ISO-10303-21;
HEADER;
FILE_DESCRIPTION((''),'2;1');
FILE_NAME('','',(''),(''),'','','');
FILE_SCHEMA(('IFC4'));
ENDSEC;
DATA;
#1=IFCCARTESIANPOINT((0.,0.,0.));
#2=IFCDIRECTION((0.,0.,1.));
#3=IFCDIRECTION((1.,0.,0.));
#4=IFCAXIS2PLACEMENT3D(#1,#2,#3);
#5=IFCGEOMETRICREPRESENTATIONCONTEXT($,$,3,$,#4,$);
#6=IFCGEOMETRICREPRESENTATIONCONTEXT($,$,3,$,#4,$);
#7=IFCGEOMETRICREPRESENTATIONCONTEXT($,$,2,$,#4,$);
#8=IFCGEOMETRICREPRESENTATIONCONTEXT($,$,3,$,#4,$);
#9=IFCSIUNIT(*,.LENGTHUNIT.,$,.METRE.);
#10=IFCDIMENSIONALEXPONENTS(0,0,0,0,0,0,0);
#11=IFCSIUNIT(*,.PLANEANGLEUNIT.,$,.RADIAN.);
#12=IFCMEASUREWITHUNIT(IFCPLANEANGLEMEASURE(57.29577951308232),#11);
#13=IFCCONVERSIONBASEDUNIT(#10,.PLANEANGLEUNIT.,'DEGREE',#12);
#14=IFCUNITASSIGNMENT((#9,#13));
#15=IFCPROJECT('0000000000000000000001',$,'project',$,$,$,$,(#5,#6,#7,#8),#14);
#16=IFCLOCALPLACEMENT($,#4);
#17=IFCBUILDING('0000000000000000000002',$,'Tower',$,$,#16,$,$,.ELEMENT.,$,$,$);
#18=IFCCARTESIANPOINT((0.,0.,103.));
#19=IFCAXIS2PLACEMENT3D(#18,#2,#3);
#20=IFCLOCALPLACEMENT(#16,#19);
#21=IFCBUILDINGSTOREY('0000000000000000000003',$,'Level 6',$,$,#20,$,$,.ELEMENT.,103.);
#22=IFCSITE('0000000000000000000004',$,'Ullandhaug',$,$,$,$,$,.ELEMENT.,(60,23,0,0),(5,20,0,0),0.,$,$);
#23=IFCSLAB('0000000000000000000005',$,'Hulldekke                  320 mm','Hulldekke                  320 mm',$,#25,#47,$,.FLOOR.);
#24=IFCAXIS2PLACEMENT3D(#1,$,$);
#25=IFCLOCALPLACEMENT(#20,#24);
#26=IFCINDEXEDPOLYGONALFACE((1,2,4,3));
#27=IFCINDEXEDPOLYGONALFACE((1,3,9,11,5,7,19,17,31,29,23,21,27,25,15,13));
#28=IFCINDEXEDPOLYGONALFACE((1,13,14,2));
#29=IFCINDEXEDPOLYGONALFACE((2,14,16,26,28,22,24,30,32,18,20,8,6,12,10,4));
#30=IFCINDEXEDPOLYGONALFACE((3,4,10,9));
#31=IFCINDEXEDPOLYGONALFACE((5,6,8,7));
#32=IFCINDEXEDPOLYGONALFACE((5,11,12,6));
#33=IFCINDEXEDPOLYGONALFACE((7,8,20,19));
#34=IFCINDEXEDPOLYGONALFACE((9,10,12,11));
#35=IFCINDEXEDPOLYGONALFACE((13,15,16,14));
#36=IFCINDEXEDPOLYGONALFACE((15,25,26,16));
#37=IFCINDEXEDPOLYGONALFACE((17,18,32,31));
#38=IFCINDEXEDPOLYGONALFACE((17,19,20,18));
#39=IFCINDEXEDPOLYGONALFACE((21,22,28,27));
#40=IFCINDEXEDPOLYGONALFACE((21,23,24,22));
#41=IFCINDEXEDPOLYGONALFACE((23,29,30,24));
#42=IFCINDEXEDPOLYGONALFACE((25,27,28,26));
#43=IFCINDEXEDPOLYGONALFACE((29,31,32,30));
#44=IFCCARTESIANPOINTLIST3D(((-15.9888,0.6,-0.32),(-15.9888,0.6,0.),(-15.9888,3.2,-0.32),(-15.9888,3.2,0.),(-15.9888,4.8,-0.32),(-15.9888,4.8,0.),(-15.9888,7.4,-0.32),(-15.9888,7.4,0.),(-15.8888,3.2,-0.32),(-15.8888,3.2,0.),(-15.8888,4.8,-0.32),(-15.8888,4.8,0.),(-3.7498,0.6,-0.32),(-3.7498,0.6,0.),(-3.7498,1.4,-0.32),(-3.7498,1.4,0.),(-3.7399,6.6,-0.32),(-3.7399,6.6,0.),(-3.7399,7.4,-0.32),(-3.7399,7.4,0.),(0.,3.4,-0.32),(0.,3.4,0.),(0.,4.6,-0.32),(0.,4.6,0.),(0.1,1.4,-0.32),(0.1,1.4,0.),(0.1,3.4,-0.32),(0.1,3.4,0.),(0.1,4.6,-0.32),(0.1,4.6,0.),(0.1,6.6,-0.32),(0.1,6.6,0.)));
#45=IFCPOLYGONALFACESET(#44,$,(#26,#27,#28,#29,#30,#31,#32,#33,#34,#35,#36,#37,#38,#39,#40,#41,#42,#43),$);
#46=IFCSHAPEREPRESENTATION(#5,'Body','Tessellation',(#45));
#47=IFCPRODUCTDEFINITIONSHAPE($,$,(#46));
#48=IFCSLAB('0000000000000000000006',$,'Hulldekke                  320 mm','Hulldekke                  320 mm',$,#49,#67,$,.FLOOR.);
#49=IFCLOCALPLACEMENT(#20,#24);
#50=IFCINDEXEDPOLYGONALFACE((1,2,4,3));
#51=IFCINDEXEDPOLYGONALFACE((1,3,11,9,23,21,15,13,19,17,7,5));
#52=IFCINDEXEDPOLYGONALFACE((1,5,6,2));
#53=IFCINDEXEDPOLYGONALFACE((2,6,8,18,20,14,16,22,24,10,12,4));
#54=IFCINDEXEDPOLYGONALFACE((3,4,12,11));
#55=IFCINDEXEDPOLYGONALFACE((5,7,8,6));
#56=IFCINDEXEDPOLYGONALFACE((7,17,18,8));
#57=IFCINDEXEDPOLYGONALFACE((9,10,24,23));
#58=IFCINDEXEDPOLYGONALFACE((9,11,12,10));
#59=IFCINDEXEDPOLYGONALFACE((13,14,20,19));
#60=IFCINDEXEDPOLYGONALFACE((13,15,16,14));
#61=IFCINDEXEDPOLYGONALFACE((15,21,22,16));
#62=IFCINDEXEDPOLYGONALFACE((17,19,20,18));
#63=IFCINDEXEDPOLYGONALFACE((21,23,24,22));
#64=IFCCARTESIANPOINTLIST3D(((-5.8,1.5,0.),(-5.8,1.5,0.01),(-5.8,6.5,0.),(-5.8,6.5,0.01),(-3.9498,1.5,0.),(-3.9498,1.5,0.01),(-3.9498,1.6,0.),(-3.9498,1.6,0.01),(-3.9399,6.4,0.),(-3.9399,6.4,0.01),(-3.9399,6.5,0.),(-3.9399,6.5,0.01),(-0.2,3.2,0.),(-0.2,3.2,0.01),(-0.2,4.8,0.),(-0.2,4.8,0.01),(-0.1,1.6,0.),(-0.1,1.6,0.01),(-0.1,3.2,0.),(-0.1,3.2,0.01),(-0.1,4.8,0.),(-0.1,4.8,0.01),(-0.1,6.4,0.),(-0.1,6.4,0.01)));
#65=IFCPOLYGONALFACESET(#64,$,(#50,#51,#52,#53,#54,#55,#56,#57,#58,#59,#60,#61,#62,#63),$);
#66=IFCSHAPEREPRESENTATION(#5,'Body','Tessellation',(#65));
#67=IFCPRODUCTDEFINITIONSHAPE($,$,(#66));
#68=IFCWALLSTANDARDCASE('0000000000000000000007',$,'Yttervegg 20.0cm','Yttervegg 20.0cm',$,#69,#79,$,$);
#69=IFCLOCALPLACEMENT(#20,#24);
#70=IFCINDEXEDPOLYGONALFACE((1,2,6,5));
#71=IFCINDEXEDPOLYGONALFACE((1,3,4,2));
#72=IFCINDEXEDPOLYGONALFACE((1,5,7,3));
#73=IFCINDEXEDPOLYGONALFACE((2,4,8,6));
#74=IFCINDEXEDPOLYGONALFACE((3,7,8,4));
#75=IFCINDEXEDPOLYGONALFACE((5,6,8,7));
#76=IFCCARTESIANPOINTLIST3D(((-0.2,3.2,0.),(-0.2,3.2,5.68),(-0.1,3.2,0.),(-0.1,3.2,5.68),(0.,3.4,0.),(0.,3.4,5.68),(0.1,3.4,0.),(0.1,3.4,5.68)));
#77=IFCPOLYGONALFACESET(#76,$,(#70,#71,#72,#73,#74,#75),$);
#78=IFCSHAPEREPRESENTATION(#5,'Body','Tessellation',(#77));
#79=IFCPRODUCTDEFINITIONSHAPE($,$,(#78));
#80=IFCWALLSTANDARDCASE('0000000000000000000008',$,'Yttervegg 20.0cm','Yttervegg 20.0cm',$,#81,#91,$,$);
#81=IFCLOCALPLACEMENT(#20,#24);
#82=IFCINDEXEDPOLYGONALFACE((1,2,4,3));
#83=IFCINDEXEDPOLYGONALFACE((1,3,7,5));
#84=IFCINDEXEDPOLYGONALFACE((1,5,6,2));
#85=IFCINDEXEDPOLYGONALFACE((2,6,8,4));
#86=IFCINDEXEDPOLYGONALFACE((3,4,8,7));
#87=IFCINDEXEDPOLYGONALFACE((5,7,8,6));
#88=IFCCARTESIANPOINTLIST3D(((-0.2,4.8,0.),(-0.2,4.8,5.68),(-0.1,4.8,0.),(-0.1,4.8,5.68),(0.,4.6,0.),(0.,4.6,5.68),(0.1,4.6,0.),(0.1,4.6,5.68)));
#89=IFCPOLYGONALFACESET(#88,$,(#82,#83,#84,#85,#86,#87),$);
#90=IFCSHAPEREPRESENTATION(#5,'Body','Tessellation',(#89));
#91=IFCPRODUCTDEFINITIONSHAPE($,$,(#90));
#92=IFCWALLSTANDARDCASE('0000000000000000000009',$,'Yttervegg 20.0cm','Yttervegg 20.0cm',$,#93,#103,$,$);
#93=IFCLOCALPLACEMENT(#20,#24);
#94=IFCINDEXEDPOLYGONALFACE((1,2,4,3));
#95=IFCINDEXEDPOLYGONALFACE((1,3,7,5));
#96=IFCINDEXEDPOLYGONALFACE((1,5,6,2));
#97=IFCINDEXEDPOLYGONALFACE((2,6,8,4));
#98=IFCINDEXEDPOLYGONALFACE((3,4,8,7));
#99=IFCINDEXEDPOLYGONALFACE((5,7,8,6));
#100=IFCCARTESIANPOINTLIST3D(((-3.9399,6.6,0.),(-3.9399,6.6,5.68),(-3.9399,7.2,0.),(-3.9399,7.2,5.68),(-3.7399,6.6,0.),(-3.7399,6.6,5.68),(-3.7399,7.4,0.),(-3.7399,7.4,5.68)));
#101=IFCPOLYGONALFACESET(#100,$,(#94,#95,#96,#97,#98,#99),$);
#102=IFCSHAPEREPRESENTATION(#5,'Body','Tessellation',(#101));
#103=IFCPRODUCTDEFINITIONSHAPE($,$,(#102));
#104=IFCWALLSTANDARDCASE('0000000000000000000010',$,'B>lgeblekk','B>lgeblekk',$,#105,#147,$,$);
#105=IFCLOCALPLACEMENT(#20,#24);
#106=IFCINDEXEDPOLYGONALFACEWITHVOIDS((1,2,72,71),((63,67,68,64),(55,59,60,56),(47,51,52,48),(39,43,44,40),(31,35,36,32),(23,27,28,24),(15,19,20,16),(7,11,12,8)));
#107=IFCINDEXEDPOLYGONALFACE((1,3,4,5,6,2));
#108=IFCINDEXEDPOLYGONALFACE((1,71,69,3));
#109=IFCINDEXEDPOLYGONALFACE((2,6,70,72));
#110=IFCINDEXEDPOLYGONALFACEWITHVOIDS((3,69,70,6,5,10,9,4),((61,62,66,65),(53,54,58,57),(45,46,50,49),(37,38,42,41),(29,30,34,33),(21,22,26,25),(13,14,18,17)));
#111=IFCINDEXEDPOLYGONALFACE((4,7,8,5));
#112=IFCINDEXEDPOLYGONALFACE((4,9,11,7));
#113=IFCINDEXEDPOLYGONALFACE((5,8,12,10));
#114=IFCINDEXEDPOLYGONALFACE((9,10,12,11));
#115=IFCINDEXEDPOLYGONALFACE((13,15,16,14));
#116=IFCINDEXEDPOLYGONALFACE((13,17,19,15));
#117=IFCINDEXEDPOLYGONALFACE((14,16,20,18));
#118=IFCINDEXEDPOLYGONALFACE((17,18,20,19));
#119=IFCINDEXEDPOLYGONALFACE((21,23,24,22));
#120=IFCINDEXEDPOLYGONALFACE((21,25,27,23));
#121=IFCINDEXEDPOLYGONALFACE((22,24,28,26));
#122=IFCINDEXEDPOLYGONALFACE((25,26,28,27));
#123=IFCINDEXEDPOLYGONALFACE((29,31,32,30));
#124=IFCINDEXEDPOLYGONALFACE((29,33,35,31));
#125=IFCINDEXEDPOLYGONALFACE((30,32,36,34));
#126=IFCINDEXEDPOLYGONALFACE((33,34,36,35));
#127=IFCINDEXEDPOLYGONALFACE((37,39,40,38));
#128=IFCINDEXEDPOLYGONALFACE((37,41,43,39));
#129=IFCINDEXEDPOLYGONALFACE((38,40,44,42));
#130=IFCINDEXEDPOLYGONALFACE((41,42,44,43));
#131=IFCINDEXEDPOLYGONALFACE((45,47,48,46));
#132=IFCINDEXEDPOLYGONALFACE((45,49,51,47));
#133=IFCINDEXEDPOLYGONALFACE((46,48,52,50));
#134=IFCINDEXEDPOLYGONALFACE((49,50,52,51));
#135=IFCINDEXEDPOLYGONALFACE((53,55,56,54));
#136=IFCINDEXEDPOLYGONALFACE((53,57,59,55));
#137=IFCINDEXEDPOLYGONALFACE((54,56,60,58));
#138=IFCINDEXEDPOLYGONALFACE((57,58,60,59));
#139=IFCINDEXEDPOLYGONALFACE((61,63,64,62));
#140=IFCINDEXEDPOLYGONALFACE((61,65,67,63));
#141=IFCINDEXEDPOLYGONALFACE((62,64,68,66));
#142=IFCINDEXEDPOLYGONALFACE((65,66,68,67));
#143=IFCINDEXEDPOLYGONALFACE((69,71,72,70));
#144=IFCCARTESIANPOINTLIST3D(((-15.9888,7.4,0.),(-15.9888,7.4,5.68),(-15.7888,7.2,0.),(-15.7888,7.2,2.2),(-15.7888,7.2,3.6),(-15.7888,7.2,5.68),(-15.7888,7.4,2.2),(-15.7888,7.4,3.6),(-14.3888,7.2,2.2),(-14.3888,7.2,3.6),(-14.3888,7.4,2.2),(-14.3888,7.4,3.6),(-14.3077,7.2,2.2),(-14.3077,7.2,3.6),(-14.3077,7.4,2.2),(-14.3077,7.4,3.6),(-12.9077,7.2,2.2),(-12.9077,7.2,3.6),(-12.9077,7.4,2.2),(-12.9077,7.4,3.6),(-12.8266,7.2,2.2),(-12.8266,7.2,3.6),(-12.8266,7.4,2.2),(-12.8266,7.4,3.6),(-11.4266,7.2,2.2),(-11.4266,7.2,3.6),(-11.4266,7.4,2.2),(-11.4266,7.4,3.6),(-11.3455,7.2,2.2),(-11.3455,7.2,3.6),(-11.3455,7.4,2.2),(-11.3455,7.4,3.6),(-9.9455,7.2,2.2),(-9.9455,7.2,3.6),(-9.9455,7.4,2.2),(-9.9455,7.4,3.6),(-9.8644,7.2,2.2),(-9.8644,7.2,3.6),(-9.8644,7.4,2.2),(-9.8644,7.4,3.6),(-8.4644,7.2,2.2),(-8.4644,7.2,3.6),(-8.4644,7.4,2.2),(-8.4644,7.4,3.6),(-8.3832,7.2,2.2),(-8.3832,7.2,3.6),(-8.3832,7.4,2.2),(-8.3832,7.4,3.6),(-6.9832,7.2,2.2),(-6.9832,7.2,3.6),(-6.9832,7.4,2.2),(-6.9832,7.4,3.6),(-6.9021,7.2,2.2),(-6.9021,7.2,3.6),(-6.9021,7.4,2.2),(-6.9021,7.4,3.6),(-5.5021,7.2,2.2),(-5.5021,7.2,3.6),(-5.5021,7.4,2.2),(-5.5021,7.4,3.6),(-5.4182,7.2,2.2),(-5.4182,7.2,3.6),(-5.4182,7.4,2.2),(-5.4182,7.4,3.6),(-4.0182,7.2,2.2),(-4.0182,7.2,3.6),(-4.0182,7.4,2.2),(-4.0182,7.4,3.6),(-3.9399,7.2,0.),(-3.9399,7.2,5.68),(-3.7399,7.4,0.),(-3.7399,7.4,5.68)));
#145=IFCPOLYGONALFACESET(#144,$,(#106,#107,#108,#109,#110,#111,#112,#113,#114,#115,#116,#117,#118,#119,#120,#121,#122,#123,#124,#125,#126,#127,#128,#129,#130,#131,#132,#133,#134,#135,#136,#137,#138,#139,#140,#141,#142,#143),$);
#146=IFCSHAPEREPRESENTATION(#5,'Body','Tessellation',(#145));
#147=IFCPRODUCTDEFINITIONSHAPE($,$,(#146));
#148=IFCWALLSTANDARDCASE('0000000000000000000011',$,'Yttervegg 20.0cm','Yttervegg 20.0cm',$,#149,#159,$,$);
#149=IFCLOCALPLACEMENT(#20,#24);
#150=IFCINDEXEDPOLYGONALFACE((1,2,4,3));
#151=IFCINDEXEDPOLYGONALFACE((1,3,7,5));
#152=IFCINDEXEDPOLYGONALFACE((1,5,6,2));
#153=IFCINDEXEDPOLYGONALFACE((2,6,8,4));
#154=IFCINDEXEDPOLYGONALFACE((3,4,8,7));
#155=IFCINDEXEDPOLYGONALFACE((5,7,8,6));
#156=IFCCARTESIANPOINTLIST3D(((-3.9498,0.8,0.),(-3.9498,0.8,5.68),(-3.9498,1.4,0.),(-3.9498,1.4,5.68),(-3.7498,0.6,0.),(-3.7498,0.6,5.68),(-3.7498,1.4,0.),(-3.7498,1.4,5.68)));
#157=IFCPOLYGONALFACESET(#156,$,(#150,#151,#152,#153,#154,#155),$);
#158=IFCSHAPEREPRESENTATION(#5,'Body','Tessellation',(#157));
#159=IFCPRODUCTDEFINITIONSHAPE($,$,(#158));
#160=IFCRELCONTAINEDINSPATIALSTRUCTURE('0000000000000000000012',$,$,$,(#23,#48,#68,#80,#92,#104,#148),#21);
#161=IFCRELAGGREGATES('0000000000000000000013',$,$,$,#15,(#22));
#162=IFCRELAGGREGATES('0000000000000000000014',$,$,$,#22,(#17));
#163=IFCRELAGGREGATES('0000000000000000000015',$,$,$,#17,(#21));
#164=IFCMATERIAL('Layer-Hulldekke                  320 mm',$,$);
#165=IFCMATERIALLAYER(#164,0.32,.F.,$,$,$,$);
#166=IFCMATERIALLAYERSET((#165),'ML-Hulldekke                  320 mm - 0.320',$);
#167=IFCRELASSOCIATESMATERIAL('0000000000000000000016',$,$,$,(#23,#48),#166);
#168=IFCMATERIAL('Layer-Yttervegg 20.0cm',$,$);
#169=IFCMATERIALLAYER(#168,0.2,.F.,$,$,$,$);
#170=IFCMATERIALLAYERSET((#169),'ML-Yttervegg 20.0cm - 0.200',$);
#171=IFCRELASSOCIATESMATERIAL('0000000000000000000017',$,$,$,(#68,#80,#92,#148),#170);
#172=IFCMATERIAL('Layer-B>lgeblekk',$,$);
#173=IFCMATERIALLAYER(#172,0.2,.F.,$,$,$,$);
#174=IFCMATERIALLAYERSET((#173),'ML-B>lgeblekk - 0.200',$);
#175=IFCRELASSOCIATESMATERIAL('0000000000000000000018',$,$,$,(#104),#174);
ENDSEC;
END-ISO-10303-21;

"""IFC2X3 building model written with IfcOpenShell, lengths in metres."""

from ifc_helpers import new_model, entity, si_unit, converted_unit, frame, origin_with_axes, place, context, project, spatial, polyline, outline, extrude, material, layer, layer_set, layer_usage, element, save


model = new_model("IFC2X3")

# Units and contexts
context_of_model_1 = context(None, 3, world=origin_with_axes())
context_of_model_2 = context(None, 3, world=origin_with_axes())
context_of_model_3 = context(None, 2, world=origin_with_axes())
context_of_model_4 = context(None, 3, world=origin_with_axes())
ifc_project = project(units=[si_unit("LENGTHUNIT", "METRE"), converted_unit("PLANEANGLEUNIT", "DEGREE", entity("IfcPlaneAngleMeasure", 57.29577951308232), si_unit("PLANEANGLEUNIT", "RADIAN"), dimensions=[0, 0, 0, 0, 0, 0, 0])], contexts=[context_of_model_1, context_of_model_2, context_of_model_3, context_of_model_4])

# Site, building, storey
site = spatial("IfcSite", under=ifc_project, Name="Ullandhaug", CompositionType="ELEMENT", RefLatitude=(60, 23, 0, 0), RefLongitude=(5, 20, 0, 0), RefElevation=0.0)
building_placement = place(None, origin_with_axes())
building = spatial("IfcBuilding", under=site, at=building_placement, Name="Tower", CompositionType="ELEMENT")
storey_placement = place(building_placement, frame((0.0, 0.0, 103.0), z_axis=(0.0, 0.0, 1.0), x_axis=(1.0, 0.0, 0.0)))
storey = spatial("IfcBuildingStorey", under=building, at=storey_placement, Name="Level 6", CompositionType="ELEMENT", Elevation=103.0)

# Slabs
ifc_material_1 = material(Name="Layer-Hulldekke                  320 mm")
ifc_layer_1 = layer(ifc_material_1, 0.32, ventilated=False)
ifc_layer_set_1 = layer_set([ifc_layer_1], Name="ML-Hulldekke                  320 mm - 0.320")
ifc_layer_usage_1 = layer_usage(ifc_layer_set_1, "AXIS2", "POSITIVE", 0.0)
slab_1_placement = place(storey_placement, frame((0.1, 1.4, 0.0), z_axis=(0.0, 0.0, 1.0), x_axis=(1.0, 0.0, 0.0)))
element("IfcSlab", 1, at=slab_1_placement, inside=storey, material=ifc_layer_usage_1, Name="Hulldekke                  320 mm", Description="Hulldekke                  320 mm", PredefinedType="FLOOR", context=context_of_model_1, shape_type="SweptSolid", body=[
    extrude(outline(polyline([(0.0, 0.0), (2.0, 0.0), (2.0, 0.1), (3.2, 0.1), (3.2, 0.0), (5.2, 0.0), (5.2, 3.8399), (6.0, 3.8399), (6.0, 16.0888), (3.4, 16.0888), (3.4, 15.9888), (1.8, 15.9888), (1.8, 16.0888), (-0.8, 16.0888), (-0.8, 3.8498), (0.0, 3.8498), (0.0, 0.0)])), frame((0.0, 0.0, 0.0), z_axis=(0.0, 0.0, 1.0), x_axis=(0.0, 1.0, 0.0)), (0.0, 0.0, -1.0), 0.32),
])
slab_2_placement = place(storey_placement, frame((-0.1, 1.6, 0.0), z_axis=(0.0, 0.0, 1.0), x_axis=(1.0, 0.0, 0.0)))
element("IfcSlab", 2, at=slab_2_placement, inside=storey, material=ifc_layer_usage_1, Name="Hulldekke                  320 mm", Description="Hulldekke                  320 mm", PredefinedType="FLOOR", context=context_of_model_1, shape_type="SweptSolid", body=[
    extrude(outline(polyline([(0.0, 0.0), (1.6, 0.0), (1.6, 0.1), (3.2, 0.1), (3.2, 0.0), (4.8, 0.0), (4.8, 3.8399), (4.9, 3.8399), (4.9, 5.7), (-0.1, 5.7), (-0.1, 3.8498), (0.0, 3.8498), (0.0, 0.0)])), frame((0.0, 0.0, 0.0), z_axis=(0.0, 0.0, 1.0), x_axis=(0.0, 1.0, 0.0)), (0.0, 0.0, 1.0), 0.01),
])

# Walls
ifc_material_2 = material(Name="Layer-Yttervegg 20.0cm")
ifc_layer_2 = layer(ifc_material_2, 0.2, ventilated=False)
ifc_layer_set_2 = layer_set([ifc_layer_2], Name="ML-Yttervegg 20.0cm - 0.200")
ifc_layer_usage_2 = layer_usage(ifc_layer_set_2, "AXIS2", "POSITIVE", 0.0)
wall_1_placement = place(storey_placement, frame((0.1, 3.4, 0.0), z_axis=(0.0, 0.0, 1.0), x_axis=(-1.0, 0.0, 0.0)))
element("IfcWallStandardCase", 3, at=wall_1_placement, inside=storey, material=ifc_layer_usage_2, Name="Yttervegg 20.0cm", Description="Yttervegg 20.0cm", context=context_of_model_1, shape_type="SweptSolid", body=[
    extrude(outline(polyline([(0.0, 0.0), (0.1, 0.0), (0.3, 0.2), (0.2, 0.2), (0.0, 0.0)])), frame((0.0, 0.0, 0.0), z_axis=(0.0, 0.0, 1.0), x_axis=(1.0, 0.0, 0.0)), (0.0, 0.0, 1.0), 5.68),
])
wall_2_placement = place(storey_placement, frame((0.0, 4.6, 0.0), z_axis=(0.0, 0.0, 1.0), x_axis=(1.0, 0.0, 0.0)))
element("IfcWallStandardCase", 4, at=wall_2_placement, inside=storey, material=ifc_layer_usage_2, Name="Yttervegg 20.0cm", Description="Yttervegg 20.0cm", context=context_of_model_1, shape_type="SweptSolid", body=[
    extrude(outline(polyline([(0.0, 0.0), (0.1, 0.0), (-0.1, 0.2), (-0.2, 0.2), (0.0, 0.0)])), origin_with_axes(), (0.0, 0.0, 1.0), 5.68),
])
wall_3_placement = place(storey_placement, frame((-3.7399, 6.6, 0.0), z_axis=(0.0, 0.0, 1.0), x_axis=(0.0, 1.0, 0.0)))
element("IfcWallStandardCase", 5, at=wall_3_placement, inside=storey, material=ifc_layer_usage_2, Name="Yttervegg 20.0cm", Description="Yttervegg 20.0cm", context=context_of_model_1, shape_type="SweptSolid", body=[
    extrude(outline(polyline([(0.0, 0.0), (0.8, 0.0), (0.6, 0.2), (0.0, 0.2), (0.0, 0.0)])), frame((0.0, 0.0, 0.0), z_axis=(0.0, 0.0, 1.0), x_axis=(1.0, 0.0, 0.0)), (0.0, 0.0, 1.0), 5.68),
])

# Wall, openings
ifc_material_3 = material(Name="Layer-B>lgeblekk")
ifc_layer_3 = layer(ifc_material_3, 0.2, ventilated=False)
ifc_layer_set_3 = layer_set([ifc_layer_3], Name="ML-B>lgeblekk - 0.200")
ifc_layer_usage_3 = layer_usage(ifc_layer_set_3, "AXIS2", "POSITIVE", 0.0)
wall_4_placement = place(storey_placement, frame((-3.7399, 7.4, 0.0), z_axis=(0.0, 0.0, 1.0), x_axis=(-1.0, 0.0, 0.0)))
wall_4 = element("IfcWallStandardCase", 6, at=wall_4_placement, inside=storey, material=ifc_layer_usage_3, Name="B>lgeblekk", Description="B>lgeblekk", context=context_of_model_1, shape_type="SweptSolid", body=[
    extrude(outline(polyline([(0.0, 0.0), (12.2489, 0.0), (12.0489, 0.2), (0.2, 0.2), (0.0, 0.0)])), frame((0.0, 0.0, 0.0), z_axis=(0.0, 0.0, 1.0), x_axis=(1.0, 0.0, 0.0)), (0.0, 0.0, 1.0), 5.68),
])
opening_1_placement = place(wall_4_placement, frame((10.6489, 0.2, 2.2), z_axis=(0.0, 0.0, 1.0), x_axis=(1.0, 0.0, 0.0)))
element("IfcOpeningElement", 7, at=opening_1_placement, cuts=wall_4, context=context_of_model_1, shape_type="SweptSolid", body=[
    extrude(outline(polyline([(0.0, 0.0), (1.4, 0.0), (1.4, 1.4), (0.0, 1.4), (0.0, 0.0)])), frame((0.0, 0.0, 0.0), z_axis=(0.0, 1.0, 0.0), x_axis=(0.0, 0.0, 1.0)), (0.0, 0.0, -1.0), 0.2),
])
opening_2_placement = place(wall_4_placement, frame((9.1678, 0.2, 2.2), z_axis=(0.0, 0.0, 1.0), x_axis=(1.0, 0.0, 0.0)))
element("IfcOpeningElement", 8, at=opening_2_placement, cuts=wall_4, context=context_of_model_1, shape_type="SweptSolid", body=[
    extrude(outline(polyline([(0.0, 0.0), (1.4, 0.0), (1.4, 1.4), (0.0, 1.4), (0.0, 0.0)])), frame((0.0, 0.0, 0.0), z_axis=(0.0, 1.0, 0.0), x_axis=(0.0, 0.0, 1.0)), (0.0, 0.0, -1.0), 0.2),
])
opening_3_placement = place(wall_4_placement, frame((7.6867, 0.2, 2.2), z_axis=(0.0, 0.0, 1.0), x_axis=(1.0, 0.0, 0.0)))
element("IfcOpeningElement", 9, at=opening_3_placement, cuts=wall_4, context=context_of_model_1, shape_type="SweptSolid", body=[
    extrude(outline(polyline([(0.0, 0.0), (1.4, 0.0), (1.4, 1.4), (0.0, 1.4), (0.0, 0.0)])), frame((0.0, 0.0, 0.0), z_axis=(0.0, 1.0, 0.0), x_axis=(0.0, 0.0, 1.0)), (0.0, 0.0, -1.0), 0.2),
])
opening_4_placement = place(wall_4_placement, frame((6.2056, 0.2, 2.2), z_axis=(0.0, 0.0, 1.0), x_axis=(1.0, 0.0, 0.0)))
element("IfcOpeningElement", 10, at=opening_4_placement, cuts=wall_4, context=context_of_model_1, shape_type="SweptSolid", body=[
    extrude(outline(polyline([(0.0, 0.0), (1.4, 0.0), (1.4, 1.4), (0.0, 1.4), (0.0, 0.0)])), frame((0.0, 0.0, 0.0), z_axis=(0.0, 1.0, 0.0), x_axis=(0.0, 0.0, 1.0)), (0.0, 0.0, -1.0), 0.2),
])
opening_5_placement = place(wall_4_placement, frame((4.7245, 0.2, 2.2), z_axis=(0.0, 0.0, 1.0), x_axis=(1.0, 0.0, 0.0)))
element("IfcOpeningElement", 11, at=opening_5_placement, cuts=wall_4, context=context_of_model_1, shape_type="SweptSolid", body=[
    extrude(outline(polyline([(0.0, 0.0), (1.4, 0.0), (1.4, 1.4), (0.0, 1.4), (0.0, 0.0)])), frame((0.0, 0.0, 0.0), z_axis=(0.0, 1.0, 0.0), x_axis=(0.0, 0.0, 1.0)), (0.0, 0.0, -1.0), 0.2),
])
opening_6_placement = place(wall_4_placement, frame((3.2434, 0.2, 2.2), z_axis=(0.0, 0.0, 1.0), x_axis=(1.0, 0.0, 0.0)))
element("IfcOpeningElement", 12, at=opening_6_placement, cuts=wall_4, context=context_of_model_1, shape_type="SweptSolid", body=[
    extrude(outline(polyline([(0.0, 0.0), (1.4, 0.0), (1.4, 1.4), (0.0, 1.4), (0.0, 0.0)])), frame((0.0, 0.0, 0.0), z_axis=(0.0, 1.0, 0.0), x_axis=(0.0, 0.0, 1.0)), (0.0, 0.0, -1.0), 0.2),
])
opening_7_placement = place(wall_4_placement, frame((1.7622, 0.2, 2.2), z_axis=(0.0, 0.0, 1.0), x_axis=(1.0, 0.0, 0.0)))
element("IfcOpeningElement", 13, at=opening_7_placement, cuts=wall_4, context=context_of_model_1, shape_type="SweptSolid", body=[
    extrude(outline(polyline([(0.0, 0.0), (1.4, 0.0), (1.4, 1.4), (0.0, 1.4), (0.0, 0.0)])), frame((0.0, 0.0, 0.0), z_axis=(0.0, 1.0, 0.0), x_axis=(0.0, 0.0, 1.0)), (0.0, 0.0, -1.0), 0.2),
])
opening_8_placement = place(wall_4_placement, frame((0.2783, 0.2, 2.2), z_axis=(0.0, 0.0, 1.0), x_axis=(1.0, 0.0, 0.0)))
element("IfcOpeningElement", 14, at=opening_8_placement, cuts=wall_4, context=context_of_model_1, shape_type="SweptSolid", body=[
    extrude(outline(polyline([(0.0, 0.0), (1.4, 0.0), (1.4, 1.4), (0.0, 1.4), (0.0, 0.0)])), frame((0.0, 0.0, 0.0), z_axis=(0.0, 1.0, 0.0), x_axis=(0.0, 0.0, 1.0)), (0.0, 0.0, -1.0), 0.2),
])

# Wall
wall_5_placement = place(storey_placement, frame((-3.7498, 0.6, 0.0), z_axis=(0.0, 0.0, 1.0), x_axis=(0.0, 1.0, 0.0)))
element("IfcWallStandardCase", 15, at=wall_5_placement, inside=storey, material=ifc_layer_usage_2, Name="Yttervegg 20.0cm", Description="Yttervegg 20.0cm", context=context_of_model_1, shape_type="SweptSolid", body=[
    extrude(outline(polyline([(0.0, 0.0), (0.8, 0.0), (0.8, 0.2), (0.2, 0.2), (0.0, 0.0)])), frame((0.0, 0.0, 0.0), z_axis=(0.0, 0.0, 1.0), x_axis=(1.0, 0.0, 0.0)), (0.0, 0.0, 1.0), 5.68),
])

save(model, "model.ifc")
